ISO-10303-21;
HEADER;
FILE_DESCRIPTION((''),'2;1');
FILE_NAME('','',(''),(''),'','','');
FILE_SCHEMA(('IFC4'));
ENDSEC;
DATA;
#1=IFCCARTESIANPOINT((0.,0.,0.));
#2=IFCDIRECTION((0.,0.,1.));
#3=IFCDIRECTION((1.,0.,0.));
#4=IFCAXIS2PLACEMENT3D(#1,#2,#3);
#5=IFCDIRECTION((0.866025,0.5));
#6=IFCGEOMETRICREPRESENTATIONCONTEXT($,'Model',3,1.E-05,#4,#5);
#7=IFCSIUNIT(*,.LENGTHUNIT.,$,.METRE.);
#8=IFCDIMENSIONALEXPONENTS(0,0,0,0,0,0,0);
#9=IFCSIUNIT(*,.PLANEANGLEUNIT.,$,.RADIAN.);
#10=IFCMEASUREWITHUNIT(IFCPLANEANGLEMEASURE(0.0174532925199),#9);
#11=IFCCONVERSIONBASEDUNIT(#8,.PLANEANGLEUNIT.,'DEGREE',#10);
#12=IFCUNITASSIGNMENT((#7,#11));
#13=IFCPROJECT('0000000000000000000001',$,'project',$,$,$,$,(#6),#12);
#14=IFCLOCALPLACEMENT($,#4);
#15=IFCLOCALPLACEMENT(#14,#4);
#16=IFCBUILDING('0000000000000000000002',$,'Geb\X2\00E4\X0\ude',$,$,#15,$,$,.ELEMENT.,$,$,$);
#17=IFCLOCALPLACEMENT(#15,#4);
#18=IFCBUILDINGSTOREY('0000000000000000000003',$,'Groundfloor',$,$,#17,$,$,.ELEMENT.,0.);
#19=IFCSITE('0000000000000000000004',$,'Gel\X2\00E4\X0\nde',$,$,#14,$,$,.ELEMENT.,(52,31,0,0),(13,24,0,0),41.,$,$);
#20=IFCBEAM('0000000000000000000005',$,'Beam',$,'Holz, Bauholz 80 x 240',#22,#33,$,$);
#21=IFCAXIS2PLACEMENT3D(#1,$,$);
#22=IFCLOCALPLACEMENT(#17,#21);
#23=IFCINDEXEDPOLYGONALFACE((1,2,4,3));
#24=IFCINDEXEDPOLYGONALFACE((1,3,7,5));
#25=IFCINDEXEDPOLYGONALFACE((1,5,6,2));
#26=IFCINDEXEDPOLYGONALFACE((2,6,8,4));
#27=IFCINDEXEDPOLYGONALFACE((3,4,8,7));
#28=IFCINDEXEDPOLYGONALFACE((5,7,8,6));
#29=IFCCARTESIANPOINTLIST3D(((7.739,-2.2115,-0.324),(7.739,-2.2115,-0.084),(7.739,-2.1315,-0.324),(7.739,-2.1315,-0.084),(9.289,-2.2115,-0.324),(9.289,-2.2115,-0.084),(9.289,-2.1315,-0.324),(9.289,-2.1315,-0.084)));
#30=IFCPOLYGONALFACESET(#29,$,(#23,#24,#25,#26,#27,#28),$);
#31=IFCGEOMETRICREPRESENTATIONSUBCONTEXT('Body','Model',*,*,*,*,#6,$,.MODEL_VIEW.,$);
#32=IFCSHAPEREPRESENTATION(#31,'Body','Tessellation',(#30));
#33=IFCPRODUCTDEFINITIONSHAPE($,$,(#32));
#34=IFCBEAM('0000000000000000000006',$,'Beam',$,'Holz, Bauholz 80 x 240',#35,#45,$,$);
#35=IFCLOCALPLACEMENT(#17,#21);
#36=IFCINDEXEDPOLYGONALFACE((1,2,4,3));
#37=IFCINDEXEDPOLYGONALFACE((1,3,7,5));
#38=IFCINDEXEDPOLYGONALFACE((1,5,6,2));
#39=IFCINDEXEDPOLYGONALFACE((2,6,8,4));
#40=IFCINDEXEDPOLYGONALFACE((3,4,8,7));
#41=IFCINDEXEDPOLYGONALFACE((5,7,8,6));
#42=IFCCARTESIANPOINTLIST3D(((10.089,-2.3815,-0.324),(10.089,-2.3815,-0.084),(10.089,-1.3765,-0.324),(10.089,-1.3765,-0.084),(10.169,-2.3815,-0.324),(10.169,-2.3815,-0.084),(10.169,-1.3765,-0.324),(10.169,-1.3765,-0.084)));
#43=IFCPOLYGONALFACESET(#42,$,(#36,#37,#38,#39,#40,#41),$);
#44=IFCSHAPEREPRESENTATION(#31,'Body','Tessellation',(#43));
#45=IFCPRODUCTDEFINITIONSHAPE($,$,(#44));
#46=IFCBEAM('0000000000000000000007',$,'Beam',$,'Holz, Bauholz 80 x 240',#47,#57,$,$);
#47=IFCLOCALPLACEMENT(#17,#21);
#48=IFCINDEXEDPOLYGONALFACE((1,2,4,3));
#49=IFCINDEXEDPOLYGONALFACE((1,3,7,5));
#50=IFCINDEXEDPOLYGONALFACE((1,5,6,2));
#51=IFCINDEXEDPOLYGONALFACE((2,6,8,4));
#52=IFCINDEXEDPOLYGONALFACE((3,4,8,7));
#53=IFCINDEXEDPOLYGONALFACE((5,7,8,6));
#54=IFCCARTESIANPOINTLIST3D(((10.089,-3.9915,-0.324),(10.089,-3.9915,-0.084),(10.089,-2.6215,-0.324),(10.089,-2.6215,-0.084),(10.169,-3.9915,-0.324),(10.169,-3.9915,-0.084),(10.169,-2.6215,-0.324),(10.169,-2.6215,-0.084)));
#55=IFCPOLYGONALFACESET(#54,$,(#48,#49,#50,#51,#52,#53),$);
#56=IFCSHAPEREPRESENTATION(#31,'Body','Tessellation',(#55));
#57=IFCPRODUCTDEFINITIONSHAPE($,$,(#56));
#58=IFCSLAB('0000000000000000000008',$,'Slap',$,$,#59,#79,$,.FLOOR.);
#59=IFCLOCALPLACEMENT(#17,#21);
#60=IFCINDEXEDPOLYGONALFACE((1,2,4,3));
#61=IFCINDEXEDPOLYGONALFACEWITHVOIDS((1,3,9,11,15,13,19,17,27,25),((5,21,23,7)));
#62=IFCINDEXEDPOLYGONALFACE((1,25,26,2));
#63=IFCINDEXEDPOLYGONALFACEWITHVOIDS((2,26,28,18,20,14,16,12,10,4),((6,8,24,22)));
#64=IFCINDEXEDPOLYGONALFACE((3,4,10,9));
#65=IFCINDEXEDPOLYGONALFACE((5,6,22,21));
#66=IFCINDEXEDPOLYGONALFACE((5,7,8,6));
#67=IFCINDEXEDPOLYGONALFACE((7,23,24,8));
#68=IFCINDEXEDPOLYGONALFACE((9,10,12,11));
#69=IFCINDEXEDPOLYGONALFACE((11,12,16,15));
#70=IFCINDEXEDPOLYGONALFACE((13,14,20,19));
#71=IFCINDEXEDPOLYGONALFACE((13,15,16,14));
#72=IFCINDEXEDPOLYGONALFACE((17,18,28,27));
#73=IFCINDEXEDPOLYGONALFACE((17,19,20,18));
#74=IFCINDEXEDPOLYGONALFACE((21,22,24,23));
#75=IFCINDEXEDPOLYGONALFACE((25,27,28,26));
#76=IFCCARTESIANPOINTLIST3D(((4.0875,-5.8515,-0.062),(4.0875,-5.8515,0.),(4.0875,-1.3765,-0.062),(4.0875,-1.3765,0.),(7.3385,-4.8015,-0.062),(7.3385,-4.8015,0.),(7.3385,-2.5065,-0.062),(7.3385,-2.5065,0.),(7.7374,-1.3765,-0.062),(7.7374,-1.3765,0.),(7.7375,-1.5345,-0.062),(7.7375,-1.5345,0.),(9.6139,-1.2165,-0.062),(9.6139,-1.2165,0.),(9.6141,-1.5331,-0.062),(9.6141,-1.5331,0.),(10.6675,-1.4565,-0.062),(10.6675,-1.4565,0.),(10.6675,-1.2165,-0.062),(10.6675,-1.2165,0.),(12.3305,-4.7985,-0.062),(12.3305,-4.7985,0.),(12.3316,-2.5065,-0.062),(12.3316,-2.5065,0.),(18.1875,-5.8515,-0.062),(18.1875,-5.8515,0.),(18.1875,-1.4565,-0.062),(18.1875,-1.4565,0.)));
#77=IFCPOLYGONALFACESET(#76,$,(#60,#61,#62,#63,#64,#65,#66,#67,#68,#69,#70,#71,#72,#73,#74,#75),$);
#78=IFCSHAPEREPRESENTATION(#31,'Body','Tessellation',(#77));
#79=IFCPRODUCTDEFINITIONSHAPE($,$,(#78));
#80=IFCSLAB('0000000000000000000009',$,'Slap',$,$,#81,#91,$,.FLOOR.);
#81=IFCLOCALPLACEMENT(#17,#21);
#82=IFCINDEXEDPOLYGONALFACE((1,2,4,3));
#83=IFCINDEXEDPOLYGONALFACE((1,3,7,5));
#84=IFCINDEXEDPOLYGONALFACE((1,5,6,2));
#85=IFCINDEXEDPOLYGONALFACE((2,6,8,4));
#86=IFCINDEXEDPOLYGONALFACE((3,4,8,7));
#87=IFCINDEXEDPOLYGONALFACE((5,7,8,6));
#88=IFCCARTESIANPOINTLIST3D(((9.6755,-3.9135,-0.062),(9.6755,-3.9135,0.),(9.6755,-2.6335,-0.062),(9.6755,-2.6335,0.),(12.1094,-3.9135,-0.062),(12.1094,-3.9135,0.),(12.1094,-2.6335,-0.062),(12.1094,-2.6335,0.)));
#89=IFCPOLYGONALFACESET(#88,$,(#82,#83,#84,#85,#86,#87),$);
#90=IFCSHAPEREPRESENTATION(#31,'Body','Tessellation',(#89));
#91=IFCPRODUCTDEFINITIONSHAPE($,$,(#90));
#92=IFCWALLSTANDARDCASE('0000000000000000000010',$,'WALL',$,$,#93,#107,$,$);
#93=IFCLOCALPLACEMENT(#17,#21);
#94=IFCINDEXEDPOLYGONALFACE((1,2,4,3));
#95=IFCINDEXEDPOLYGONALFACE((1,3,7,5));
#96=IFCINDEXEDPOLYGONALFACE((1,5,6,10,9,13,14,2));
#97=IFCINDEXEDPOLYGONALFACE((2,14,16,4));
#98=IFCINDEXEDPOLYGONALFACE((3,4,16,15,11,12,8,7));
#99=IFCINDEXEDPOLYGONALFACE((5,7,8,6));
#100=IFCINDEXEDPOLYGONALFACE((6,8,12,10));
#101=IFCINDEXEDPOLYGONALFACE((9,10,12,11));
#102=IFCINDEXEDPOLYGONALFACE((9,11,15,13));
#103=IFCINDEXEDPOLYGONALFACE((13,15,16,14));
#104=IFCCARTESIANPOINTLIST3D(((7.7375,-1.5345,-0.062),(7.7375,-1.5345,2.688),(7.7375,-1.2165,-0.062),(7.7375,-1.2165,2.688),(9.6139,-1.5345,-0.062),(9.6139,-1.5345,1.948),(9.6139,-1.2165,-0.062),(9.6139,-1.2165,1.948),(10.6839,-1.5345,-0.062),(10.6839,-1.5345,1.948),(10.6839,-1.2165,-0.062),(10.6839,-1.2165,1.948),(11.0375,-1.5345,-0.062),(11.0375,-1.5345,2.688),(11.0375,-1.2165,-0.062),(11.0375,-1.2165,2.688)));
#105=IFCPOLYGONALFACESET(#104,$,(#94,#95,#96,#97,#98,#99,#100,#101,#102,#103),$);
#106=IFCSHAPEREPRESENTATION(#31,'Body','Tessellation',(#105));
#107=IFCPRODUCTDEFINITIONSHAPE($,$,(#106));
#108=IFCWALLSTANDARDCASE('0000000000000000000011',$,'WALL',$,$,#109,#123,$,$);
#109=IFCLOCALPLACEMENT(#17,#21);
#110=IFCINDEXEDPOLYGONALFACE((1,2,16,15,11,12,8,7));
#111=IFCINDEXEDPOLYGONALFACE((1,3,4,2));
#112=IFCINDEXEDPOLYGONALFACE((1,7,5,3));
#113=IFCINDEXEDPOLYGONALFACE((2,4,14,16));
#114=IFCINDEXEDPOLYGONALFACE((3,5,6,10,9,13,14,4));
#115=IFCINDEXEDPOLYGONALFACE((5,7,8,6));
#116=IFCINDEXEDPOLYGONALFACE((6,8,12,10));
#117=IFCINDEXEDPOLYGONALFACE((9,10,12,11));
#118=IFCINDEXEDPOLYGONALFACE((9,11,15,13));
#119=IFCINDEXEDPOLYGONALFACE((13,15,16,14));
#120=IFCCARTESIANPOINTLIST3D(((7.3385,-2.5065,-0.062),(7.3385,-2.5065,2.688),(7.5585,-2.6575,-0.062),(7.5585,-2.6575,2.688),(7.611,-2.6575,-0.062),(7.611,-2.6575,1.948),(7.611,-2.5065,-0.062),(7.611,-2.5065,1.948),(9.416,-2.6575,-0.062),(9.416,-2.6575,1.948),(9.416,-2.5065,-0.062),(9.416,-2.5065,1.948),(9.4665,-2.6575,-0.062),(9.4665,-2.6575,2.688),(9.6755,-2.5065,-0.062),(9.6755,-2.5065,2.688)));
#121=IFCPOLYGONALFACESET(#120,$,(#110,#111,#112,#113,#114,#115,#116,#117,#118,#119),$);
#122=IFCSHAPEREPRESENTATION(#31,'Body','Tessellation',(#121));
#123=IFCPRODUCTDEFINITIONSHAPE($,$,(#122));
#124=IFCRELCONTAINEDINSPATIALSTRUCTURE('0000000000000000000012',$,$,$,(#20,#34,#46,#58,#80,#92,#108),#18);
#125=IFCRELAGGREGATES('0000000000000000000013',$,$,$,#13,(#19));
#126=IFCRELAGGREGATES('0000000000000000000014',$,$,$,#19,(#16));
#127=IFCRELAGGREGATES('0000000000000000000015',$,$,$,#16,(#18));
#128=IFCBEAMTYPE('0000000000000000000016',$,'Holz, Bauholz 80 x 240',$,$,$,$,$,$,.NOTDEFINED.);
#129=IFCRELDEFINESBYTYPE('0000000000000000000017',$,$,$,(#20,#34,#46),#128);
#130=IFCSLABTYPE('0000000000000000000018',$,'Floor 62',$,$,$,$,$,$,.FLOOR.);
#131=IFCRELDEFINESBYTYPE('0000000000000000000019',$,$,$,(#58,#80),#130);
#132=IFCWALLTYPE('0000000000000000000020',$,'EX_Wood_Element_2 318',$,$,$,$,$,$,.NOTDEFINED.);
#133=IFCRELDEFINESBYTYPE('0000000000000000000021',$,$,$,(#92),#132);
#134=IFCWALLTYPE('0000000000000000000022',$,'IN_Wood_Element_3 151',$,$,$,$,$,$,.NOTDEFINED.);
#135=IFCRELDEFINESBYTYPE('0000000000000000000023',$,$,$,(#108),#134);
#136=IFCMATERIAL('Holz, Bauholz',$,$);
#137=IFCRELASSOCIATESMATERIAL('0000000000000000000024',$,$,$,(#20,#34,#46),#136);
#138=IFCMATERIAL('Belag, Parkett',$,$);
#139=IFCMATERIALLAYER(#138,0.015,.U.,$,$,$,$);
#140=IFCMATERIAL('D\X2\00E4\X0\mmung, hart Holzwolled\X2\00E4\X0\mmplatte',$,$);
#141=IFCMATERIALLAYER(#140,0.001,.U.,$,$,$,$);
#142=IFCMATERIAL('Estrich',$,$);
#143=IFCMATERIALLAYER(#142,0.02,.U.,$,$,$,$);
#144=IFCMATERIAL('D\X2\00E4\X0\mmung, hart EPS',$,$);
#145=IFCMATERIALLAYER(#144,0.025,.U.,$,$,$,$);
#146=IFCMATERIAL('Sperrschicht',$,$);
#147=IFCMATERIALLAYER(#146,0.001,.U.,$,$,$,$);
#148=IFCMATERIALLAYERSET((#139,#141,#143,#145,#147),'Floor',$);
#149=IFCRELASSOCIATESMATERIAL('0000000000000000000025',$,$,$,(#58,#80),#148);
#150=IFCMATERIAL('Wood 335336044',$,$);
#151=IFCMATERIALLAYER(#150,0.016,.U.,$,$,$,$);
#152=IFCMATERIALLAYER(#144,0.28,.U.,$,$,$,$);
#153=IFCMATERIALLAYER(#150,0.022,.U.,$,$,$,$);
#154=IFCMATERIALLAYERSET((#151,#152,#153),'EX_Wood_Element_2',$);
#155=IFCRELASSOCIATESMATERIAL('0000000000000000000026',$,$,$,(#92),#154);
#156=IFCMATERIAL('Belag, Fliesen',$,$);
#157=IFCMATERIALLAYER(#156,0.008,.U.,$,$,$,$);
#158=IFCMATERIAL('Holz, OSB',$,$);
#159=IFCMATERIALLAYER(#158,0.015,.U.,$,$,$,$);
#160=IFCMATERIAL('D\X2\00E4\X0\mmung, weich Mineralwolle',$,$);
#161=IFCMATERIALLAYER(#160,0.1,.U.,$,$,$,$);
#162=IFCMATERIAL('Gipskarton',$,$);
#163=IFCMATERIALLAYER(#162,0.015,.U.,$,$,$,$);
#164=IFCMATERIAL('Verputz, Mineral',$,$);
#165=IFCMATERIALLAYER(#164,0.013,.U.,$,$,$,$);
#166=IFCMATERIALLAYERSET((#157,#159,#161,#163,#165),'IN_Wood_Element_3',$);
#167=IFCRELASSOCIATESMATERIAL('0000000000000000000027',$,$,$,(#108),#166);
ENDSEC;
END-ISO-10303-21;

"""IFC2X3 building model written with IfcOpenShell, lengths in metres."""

from ifc_helpers import new_model, entity, si_unit, converted_unit, direction, frame, frame_2d, origin_with_axes, origin_2d_with_axis, place, context, subcontext, project, spatial, polyline, rectangle, outline, extrude, material, layer, layer_set, layer_usage, type_object, element, save


model = new_model("IFC2X3")

# Units and contexts
model_context = context("Model", 3, precision=1e-05, world=origin_with_axes(), true_north=direction((0.866025, 0.5)))
body_context = subcontext(model_context, "Body", "Model", "MODEL_VIEW")
ifc_project = project(units=[si_unit("LENGTHUNIT", "METRE"), converted_unit("PLANEANGLEUNIT", "DEGREE", entity("IfcPlaneAngleMeasure", 0.0174532925199), si_unit("PLANEANGLEUNIT", "RADIAN"), dimensions=[0, 0, 0, 0, 0, 0, 0])], contexts=[model_context])

# Site, building, storey
site_placement = place(None, origin_with_axes())
site = spatial("IfcSite", under=ifc_project, at=site_placement, Name="Gelände", CompositionType="ELEMENT", RefLatitude=(52, 31, 0, 0), RefLongitude=(13, 24, 0, 0), RefElevation=41.0)
building_placement = place(site_placement, origin_with_axes())
building = spatial("IfcBuilding", under=site, at=building_placement, Name="Gebäude", CompositionType="ELEMENT")
storey_placement = place(building_placement, origin_with_axes())
storey = spatial("IfcBuildingStorey", under=building, at=storey_placement, Name="Groundfloor", CompositionType="ELEMENT", Elevation=0.0)

# Shared definitions
ifc_material_1 = material(Name="Holz, Bauholz")

# Beams
beam_type = type_object("IfcBeamType", Name="Holz, Bauholz 80 x 240", PredefinedType="NOTDEFINED")
for number, where, z_axis, x_axis, name in (
    (1, (9.289, -2.1715, -0.084), (0.0, 0.0, 1.0), (0.0, 1.0, 0.0), "Beam"),
):
    element("IfcBeam", number, at=place(storey_placement, frame(where, z_axis=z_axis, x_axis=x_axis)), inside=storey, type_object=beam_type, material=ifc_material_1, Name=name, ObjectType="Holz, Bauholz 80 x 240", context=body_context, shape_type="SweptSolid", body=[
        extrude(rectangle(XDim=0.24, YDim=0.08, at=frame_2d((-0.12, 0.0), x_axis=(1.0, 0.0))), frame((0.0, 0.0, 0.0), z_axis=(0.0, 1.0, 0.0), x_axis=(0.0, 0.0, 1.0)), (0.0, 0.0, 1.0), 1.55),
    ])
beam_1_placement = place(storey_placement, frame((10.129, -2.3815, -0.084), z_axis=(0.0, 0.0, 1.0), x_axis=(1.0, 0.0, 0.0)))
element("IfcBeam", 2, at=beam_1_placement, inside=storey, type_object=beam_type, material=ifc_material_1, Name="Beam", ObjectType="Holz, Bauholz 80 x 240", context=body_context, shape_type="SweptSolid", body=[
    extrude(rectangle(XDim=0.24, YDim=0.08, at=frame_2d((-0.12, 0.0), x_axis=(1.0, 0.0))), frame((0.0, 0.0, 0.0), z_axis=(0.0, 1.0, 0.0), x_axis=(0.0, 0.0, 1.0)), (0.0, 0.0, 1.0), 1.005),
])
beam_2_placement = place(storey_placement, frame((10.129, -3.9915, -0.084), z_axis=(0.0, 0.0, 1.0), x_axis=(1.0, 0.0, 0.0)))
element("IfcBeam", 3, at=beam_2_placement, inside=storey, type_object=beam_type, material=ifc_material_1, Name="Beam", ObjectType="Holz, Bauholz 80 x 240", context=body_context, shape_type="SweptSolid", body=[
    extrude(rectangle(XDim=0.24, YDim=0.08, at=frame_2d((-0.12, 0.0), x_axis=(1.0, 0.0))), frame((0.0, 0.0, 0.0), z_axis=(0.0, 1.0, 0.0), x_axis=(0.0, 0.0, 1.0)), (0.0, 0.0, 1.0), 1.37),
])

# Slab, opening
ifc_material_2 = material(Name="Belag, Parkett")
ifc_layer_1 = layer(ifc_material_2, 0.015, ventilated="UNKNOWN")
ifc_material_3 = material(Name="Dämmung, hart Holzwolledämmplatte")
ifc_layer_2 = layer(ifc_material_3, 0.001, ventilated="UNKNOWN")
ifc_material_4 = material(Name="Estrich")
ifc_layer_3 = layer(ifc_material_4, 0.02, ventilated="UNKNOWN")
ifc_material_5 = material(Name="Dämmung, hart EPS")
ifc_layer_4 = layer(ifc_material_5, 0.025, ventilated="UNKNOWN")
ifc_material_6 = material(Name="Sperrschicht")
ifc_layer_5 = layer(ifc_material_6, 0.001, ventilated="UNKNOWN")
ifc_layer_set_1 = layer_set([ifc_layer_1, ifc_layer_2, ifc_layer_3, ifc_layer_4, ifc_layer_5], Name="Floor")
ifc_layer_usage_1 = layer_usage(ifc_layer_set_1, "AXIS3", "NEGATIVE", 0.062)
slab_type = type_object("IfcSlabType", Name="Floor 62", PredefinedType="FLOOR")
slab_1_placement = place(storey_placement, frame((7.7374, -1.3765, 0.0), z_axis=(0.0, 0.0, 1.0), x_axis=(1.0, 0.0, 0.0)))
slab_1 = element("IfcSlab", 4, at=slab_1_placement, inside=storey, type_object=slab_type, material=ifc_layer_usage_1, Name="Slap", PredefinedType="FLOOR", context=body_context, shape_type="SweptSolid", body=[
    extrude(outline(polyline([(0.0, 0.0), (-3.6499, 0.0), (-3.6499, -4.475), (10.4501, -4.475), (10.4501, -0.08), (2.9301, -0.08), (2.9301, 0.16), (1.8765, 0.16), (1.8767, -0.1566), (0.0001, -0.158), (0.0, 0.0)])), frame((0.0, 0.0, -0.062), z_axis=(0.0, 0.0, 1.0), x_axis=(1.0, 0.0, 0.0)), (0.0, 0.0, 1.0), 0.062),
])
opening_1_placement = place(slab_1_placement, origin_with_axes())
element("IfcOpeningElement", 5, at=opening_1_placement, cuts=slab_1, context=body_context, shape_type="SweptSolid", body=[
    extrude(outline(polyline([(-0.3989, -3.425), (4.5931, -3.422), (4.5942, -1.13), (-0.3989, -1.13), (-0.3989, -3.425)])), frame((0.0, 0.0, -0.062), z_axis=(0.0, 0.0, 1.0), x_axis=(1.0, 0.0, 0.0)), (0.0, 0.0, 1.0), 0.062),
])

# Slab
ifc_layer_usage_2 = layer_usage(ifc_layer_set_1, "AXIS3", "NEGATIVE", 0.062)
slab_2_placement = place(storey_placement, frame((9.6755, -2.6335, 0.0), z_axis=(0.0, 0.0, 1.0), x_axis=(1.0, 0.0, 0.0)))
element("IfcSlab", 6, at=slab_2_placement, inside=storey, type_object=slab_type, material=ifc_layer_usage_2, Name="Slap", PredefinedType="FLOOR", context=body_context, shape_type="SweptSolid", body=[
    extrude(outline(polyline([(0.0, 0.0), (0.0, -1.28), (2.4339, -1.28), (2.4339, 0.0), (0.0, 0.0)])), frame((0.0, 0.0, -0.062), z_axis=(0.0, 0.0, 1.0), x_axis=(1.0, 0.0, 0.0)), (0.0, 0.0, 1.0), 0.062),
])

# Shared definitions
ifc_material_7 = material(Name="Belag, Fliesen")
ifc_material_8 = material(Name="Holz, OSB")
ifc_material_9 = material(Name="Dämmung, weich Mineralwolle")

# Wall, opening
ifc_material_10 = material(Name="Wood 335336044")
ifc_layer_6 = layer(ifc_material_10, 0.016, ventilated="UNKNOWN")
ifc_layer_7 = layer(ifc_material_5, 0.28, ventilated="UNKNOWN")
ifc_layer_8 = layer(ifc_material_10, 0.022, ventilated="UNKNOWN")
ifc_layer_set_2 = layer_set([ifc_layer_6, ifc_layer_7, ifc_layer_8], Name="EX_Wood_Element_2")
ifc_layer_usage_3 = layer_usage(ifc_layer_set_2, "AXIS2", "NEGATIVE", 0.0)
wall_type_1 = type_object("IfcWallType", Name="EX_Wood_Element_2 318", PredefinedType="NOTDEFINED")
wall_1_placement = place(storey_placement, frame((7.7375, -1.2165, -0.062), z_axis=(0.0, 0.0, 1.0), x_axis=(1.0, 0.0, 0.0)))
wall_1 = element("IfcWallStandardCase", 7, at=wall_1_placement, inside=storey, type_object=wall_type_1, material=ifc_layer_usage_3, Name="WALL", context=body_context, shape_type="SweptSolid", body=[
    extrude(outline(polyline([(0.0, -0.318), (3.3, -0.318), (3.3, 0.0), (0.0, 0.0), (0.0, -0.318)])), origin_with_axes(), (0.0, 0.0, 1.0), 2.75),
])
opening_2_placement = place(wall_1_placement, frame((2.4114, 0.0, 0.0), z_axis=(0.0, 0.0, 1.0), x_axis=(1.0, 0.0, 0.0)))
element("IfcOpeningElement", 8, at=opening_2_placement, cuts=wall_1, context=body_context, shape_type="SweptSolid", body=[
    extrude(rectangle(XDim=1.07, YDim=2.01, at=origin_2d_with_axis()), frame((0.0, -0.318, 1.005), z_axis=(0.0, 1.0, 0.0), x_axis=(1.0, 0.0, 0.0)), (0.0, 0.0, 1.0), 0.954),
])

# Wall, opening
ifc_layer_9 = layer(ifc_material_7, 0.008, ventilated="UNKNOWN")
ifc_layer_10 = layer(ifc_material_8, 0.015, ventilated="UNKNOWN")
ifc_layer_11 = layer(ifc_material_9, 0.1, ventilated="UNKNOWN")
ifc_material_11 = material(Name="Gipskarton")
ifc_layer_12 = layer(ifc_material_11, 0.015, ventilated="UNKNOWN")
ifc_material_12 = material(Name="Verputz, Mineral")
ifc_layer_13 = layer(ifc_material_12, 0.013, ventilated="UNKNOWN")
ifc_layer_set_3 = layer_set([ifc_layer_9, ifc_layer_10, ifc_layer_11, ifc_layer_12, ifc_layer_13], Name="IN_Wood_Element_3")
ifc_layer_usage_4 = layer_usage(ifc_layer_set_3, "AXIS2", "NEGATIVE", 0.151)
wall_type_2 = type_object("IfcWallType", Name="IN_Wood_Element_3 151", PredefinedType="NOTDEFINED")
wall_2_placement = place(storey_placement, frame((9.6755, -2.5065, -0.062), z_axis=(0.0, 0.0, 1.0), x_axis=(-1.0, 0.0, 0.0)))
wall_2 = element("IfcWallStandardCase", 9, at=wall_2_placement, inside=storey, type_object=wall_type_2, material=ifc_layer_usage_4, Name="WALL", context=body_context, shape_type="SweptSolid", body=[
    extrude(outline(polyline([(0.0, 0.0), (2.337, 0.0), (2.117, 0.151), (0.209, 0.151), (0.0, 0.0)])), origin_with_axes(), (0.0, 0.0, 1.0), 2.75),
])
opening_3_placement = place(wall_2_placement, frame((1.162, 0.0, 0.0), z_axis=(0.0, 0.0, 1.0), x_axis=(1.0, 0.0, 0.0)))
element("IfcOpeningElement", 10, at=opening_3_placement, cuts=wall_2, context=body_context, shape_type="SweptSolid", body=[
    extrude(rectangle(XDim=1.805, YDim=2.01, at=origin_2d_with_axis()), frame((0.0, -0.151, 1.005), z_axis=(0.0, -1.0, 0.0), x_axis=(1.0, 0.0, 0.0)), (0.0, 0.0, -1.0), 0.453),
])

save(model, "model.ifc")
